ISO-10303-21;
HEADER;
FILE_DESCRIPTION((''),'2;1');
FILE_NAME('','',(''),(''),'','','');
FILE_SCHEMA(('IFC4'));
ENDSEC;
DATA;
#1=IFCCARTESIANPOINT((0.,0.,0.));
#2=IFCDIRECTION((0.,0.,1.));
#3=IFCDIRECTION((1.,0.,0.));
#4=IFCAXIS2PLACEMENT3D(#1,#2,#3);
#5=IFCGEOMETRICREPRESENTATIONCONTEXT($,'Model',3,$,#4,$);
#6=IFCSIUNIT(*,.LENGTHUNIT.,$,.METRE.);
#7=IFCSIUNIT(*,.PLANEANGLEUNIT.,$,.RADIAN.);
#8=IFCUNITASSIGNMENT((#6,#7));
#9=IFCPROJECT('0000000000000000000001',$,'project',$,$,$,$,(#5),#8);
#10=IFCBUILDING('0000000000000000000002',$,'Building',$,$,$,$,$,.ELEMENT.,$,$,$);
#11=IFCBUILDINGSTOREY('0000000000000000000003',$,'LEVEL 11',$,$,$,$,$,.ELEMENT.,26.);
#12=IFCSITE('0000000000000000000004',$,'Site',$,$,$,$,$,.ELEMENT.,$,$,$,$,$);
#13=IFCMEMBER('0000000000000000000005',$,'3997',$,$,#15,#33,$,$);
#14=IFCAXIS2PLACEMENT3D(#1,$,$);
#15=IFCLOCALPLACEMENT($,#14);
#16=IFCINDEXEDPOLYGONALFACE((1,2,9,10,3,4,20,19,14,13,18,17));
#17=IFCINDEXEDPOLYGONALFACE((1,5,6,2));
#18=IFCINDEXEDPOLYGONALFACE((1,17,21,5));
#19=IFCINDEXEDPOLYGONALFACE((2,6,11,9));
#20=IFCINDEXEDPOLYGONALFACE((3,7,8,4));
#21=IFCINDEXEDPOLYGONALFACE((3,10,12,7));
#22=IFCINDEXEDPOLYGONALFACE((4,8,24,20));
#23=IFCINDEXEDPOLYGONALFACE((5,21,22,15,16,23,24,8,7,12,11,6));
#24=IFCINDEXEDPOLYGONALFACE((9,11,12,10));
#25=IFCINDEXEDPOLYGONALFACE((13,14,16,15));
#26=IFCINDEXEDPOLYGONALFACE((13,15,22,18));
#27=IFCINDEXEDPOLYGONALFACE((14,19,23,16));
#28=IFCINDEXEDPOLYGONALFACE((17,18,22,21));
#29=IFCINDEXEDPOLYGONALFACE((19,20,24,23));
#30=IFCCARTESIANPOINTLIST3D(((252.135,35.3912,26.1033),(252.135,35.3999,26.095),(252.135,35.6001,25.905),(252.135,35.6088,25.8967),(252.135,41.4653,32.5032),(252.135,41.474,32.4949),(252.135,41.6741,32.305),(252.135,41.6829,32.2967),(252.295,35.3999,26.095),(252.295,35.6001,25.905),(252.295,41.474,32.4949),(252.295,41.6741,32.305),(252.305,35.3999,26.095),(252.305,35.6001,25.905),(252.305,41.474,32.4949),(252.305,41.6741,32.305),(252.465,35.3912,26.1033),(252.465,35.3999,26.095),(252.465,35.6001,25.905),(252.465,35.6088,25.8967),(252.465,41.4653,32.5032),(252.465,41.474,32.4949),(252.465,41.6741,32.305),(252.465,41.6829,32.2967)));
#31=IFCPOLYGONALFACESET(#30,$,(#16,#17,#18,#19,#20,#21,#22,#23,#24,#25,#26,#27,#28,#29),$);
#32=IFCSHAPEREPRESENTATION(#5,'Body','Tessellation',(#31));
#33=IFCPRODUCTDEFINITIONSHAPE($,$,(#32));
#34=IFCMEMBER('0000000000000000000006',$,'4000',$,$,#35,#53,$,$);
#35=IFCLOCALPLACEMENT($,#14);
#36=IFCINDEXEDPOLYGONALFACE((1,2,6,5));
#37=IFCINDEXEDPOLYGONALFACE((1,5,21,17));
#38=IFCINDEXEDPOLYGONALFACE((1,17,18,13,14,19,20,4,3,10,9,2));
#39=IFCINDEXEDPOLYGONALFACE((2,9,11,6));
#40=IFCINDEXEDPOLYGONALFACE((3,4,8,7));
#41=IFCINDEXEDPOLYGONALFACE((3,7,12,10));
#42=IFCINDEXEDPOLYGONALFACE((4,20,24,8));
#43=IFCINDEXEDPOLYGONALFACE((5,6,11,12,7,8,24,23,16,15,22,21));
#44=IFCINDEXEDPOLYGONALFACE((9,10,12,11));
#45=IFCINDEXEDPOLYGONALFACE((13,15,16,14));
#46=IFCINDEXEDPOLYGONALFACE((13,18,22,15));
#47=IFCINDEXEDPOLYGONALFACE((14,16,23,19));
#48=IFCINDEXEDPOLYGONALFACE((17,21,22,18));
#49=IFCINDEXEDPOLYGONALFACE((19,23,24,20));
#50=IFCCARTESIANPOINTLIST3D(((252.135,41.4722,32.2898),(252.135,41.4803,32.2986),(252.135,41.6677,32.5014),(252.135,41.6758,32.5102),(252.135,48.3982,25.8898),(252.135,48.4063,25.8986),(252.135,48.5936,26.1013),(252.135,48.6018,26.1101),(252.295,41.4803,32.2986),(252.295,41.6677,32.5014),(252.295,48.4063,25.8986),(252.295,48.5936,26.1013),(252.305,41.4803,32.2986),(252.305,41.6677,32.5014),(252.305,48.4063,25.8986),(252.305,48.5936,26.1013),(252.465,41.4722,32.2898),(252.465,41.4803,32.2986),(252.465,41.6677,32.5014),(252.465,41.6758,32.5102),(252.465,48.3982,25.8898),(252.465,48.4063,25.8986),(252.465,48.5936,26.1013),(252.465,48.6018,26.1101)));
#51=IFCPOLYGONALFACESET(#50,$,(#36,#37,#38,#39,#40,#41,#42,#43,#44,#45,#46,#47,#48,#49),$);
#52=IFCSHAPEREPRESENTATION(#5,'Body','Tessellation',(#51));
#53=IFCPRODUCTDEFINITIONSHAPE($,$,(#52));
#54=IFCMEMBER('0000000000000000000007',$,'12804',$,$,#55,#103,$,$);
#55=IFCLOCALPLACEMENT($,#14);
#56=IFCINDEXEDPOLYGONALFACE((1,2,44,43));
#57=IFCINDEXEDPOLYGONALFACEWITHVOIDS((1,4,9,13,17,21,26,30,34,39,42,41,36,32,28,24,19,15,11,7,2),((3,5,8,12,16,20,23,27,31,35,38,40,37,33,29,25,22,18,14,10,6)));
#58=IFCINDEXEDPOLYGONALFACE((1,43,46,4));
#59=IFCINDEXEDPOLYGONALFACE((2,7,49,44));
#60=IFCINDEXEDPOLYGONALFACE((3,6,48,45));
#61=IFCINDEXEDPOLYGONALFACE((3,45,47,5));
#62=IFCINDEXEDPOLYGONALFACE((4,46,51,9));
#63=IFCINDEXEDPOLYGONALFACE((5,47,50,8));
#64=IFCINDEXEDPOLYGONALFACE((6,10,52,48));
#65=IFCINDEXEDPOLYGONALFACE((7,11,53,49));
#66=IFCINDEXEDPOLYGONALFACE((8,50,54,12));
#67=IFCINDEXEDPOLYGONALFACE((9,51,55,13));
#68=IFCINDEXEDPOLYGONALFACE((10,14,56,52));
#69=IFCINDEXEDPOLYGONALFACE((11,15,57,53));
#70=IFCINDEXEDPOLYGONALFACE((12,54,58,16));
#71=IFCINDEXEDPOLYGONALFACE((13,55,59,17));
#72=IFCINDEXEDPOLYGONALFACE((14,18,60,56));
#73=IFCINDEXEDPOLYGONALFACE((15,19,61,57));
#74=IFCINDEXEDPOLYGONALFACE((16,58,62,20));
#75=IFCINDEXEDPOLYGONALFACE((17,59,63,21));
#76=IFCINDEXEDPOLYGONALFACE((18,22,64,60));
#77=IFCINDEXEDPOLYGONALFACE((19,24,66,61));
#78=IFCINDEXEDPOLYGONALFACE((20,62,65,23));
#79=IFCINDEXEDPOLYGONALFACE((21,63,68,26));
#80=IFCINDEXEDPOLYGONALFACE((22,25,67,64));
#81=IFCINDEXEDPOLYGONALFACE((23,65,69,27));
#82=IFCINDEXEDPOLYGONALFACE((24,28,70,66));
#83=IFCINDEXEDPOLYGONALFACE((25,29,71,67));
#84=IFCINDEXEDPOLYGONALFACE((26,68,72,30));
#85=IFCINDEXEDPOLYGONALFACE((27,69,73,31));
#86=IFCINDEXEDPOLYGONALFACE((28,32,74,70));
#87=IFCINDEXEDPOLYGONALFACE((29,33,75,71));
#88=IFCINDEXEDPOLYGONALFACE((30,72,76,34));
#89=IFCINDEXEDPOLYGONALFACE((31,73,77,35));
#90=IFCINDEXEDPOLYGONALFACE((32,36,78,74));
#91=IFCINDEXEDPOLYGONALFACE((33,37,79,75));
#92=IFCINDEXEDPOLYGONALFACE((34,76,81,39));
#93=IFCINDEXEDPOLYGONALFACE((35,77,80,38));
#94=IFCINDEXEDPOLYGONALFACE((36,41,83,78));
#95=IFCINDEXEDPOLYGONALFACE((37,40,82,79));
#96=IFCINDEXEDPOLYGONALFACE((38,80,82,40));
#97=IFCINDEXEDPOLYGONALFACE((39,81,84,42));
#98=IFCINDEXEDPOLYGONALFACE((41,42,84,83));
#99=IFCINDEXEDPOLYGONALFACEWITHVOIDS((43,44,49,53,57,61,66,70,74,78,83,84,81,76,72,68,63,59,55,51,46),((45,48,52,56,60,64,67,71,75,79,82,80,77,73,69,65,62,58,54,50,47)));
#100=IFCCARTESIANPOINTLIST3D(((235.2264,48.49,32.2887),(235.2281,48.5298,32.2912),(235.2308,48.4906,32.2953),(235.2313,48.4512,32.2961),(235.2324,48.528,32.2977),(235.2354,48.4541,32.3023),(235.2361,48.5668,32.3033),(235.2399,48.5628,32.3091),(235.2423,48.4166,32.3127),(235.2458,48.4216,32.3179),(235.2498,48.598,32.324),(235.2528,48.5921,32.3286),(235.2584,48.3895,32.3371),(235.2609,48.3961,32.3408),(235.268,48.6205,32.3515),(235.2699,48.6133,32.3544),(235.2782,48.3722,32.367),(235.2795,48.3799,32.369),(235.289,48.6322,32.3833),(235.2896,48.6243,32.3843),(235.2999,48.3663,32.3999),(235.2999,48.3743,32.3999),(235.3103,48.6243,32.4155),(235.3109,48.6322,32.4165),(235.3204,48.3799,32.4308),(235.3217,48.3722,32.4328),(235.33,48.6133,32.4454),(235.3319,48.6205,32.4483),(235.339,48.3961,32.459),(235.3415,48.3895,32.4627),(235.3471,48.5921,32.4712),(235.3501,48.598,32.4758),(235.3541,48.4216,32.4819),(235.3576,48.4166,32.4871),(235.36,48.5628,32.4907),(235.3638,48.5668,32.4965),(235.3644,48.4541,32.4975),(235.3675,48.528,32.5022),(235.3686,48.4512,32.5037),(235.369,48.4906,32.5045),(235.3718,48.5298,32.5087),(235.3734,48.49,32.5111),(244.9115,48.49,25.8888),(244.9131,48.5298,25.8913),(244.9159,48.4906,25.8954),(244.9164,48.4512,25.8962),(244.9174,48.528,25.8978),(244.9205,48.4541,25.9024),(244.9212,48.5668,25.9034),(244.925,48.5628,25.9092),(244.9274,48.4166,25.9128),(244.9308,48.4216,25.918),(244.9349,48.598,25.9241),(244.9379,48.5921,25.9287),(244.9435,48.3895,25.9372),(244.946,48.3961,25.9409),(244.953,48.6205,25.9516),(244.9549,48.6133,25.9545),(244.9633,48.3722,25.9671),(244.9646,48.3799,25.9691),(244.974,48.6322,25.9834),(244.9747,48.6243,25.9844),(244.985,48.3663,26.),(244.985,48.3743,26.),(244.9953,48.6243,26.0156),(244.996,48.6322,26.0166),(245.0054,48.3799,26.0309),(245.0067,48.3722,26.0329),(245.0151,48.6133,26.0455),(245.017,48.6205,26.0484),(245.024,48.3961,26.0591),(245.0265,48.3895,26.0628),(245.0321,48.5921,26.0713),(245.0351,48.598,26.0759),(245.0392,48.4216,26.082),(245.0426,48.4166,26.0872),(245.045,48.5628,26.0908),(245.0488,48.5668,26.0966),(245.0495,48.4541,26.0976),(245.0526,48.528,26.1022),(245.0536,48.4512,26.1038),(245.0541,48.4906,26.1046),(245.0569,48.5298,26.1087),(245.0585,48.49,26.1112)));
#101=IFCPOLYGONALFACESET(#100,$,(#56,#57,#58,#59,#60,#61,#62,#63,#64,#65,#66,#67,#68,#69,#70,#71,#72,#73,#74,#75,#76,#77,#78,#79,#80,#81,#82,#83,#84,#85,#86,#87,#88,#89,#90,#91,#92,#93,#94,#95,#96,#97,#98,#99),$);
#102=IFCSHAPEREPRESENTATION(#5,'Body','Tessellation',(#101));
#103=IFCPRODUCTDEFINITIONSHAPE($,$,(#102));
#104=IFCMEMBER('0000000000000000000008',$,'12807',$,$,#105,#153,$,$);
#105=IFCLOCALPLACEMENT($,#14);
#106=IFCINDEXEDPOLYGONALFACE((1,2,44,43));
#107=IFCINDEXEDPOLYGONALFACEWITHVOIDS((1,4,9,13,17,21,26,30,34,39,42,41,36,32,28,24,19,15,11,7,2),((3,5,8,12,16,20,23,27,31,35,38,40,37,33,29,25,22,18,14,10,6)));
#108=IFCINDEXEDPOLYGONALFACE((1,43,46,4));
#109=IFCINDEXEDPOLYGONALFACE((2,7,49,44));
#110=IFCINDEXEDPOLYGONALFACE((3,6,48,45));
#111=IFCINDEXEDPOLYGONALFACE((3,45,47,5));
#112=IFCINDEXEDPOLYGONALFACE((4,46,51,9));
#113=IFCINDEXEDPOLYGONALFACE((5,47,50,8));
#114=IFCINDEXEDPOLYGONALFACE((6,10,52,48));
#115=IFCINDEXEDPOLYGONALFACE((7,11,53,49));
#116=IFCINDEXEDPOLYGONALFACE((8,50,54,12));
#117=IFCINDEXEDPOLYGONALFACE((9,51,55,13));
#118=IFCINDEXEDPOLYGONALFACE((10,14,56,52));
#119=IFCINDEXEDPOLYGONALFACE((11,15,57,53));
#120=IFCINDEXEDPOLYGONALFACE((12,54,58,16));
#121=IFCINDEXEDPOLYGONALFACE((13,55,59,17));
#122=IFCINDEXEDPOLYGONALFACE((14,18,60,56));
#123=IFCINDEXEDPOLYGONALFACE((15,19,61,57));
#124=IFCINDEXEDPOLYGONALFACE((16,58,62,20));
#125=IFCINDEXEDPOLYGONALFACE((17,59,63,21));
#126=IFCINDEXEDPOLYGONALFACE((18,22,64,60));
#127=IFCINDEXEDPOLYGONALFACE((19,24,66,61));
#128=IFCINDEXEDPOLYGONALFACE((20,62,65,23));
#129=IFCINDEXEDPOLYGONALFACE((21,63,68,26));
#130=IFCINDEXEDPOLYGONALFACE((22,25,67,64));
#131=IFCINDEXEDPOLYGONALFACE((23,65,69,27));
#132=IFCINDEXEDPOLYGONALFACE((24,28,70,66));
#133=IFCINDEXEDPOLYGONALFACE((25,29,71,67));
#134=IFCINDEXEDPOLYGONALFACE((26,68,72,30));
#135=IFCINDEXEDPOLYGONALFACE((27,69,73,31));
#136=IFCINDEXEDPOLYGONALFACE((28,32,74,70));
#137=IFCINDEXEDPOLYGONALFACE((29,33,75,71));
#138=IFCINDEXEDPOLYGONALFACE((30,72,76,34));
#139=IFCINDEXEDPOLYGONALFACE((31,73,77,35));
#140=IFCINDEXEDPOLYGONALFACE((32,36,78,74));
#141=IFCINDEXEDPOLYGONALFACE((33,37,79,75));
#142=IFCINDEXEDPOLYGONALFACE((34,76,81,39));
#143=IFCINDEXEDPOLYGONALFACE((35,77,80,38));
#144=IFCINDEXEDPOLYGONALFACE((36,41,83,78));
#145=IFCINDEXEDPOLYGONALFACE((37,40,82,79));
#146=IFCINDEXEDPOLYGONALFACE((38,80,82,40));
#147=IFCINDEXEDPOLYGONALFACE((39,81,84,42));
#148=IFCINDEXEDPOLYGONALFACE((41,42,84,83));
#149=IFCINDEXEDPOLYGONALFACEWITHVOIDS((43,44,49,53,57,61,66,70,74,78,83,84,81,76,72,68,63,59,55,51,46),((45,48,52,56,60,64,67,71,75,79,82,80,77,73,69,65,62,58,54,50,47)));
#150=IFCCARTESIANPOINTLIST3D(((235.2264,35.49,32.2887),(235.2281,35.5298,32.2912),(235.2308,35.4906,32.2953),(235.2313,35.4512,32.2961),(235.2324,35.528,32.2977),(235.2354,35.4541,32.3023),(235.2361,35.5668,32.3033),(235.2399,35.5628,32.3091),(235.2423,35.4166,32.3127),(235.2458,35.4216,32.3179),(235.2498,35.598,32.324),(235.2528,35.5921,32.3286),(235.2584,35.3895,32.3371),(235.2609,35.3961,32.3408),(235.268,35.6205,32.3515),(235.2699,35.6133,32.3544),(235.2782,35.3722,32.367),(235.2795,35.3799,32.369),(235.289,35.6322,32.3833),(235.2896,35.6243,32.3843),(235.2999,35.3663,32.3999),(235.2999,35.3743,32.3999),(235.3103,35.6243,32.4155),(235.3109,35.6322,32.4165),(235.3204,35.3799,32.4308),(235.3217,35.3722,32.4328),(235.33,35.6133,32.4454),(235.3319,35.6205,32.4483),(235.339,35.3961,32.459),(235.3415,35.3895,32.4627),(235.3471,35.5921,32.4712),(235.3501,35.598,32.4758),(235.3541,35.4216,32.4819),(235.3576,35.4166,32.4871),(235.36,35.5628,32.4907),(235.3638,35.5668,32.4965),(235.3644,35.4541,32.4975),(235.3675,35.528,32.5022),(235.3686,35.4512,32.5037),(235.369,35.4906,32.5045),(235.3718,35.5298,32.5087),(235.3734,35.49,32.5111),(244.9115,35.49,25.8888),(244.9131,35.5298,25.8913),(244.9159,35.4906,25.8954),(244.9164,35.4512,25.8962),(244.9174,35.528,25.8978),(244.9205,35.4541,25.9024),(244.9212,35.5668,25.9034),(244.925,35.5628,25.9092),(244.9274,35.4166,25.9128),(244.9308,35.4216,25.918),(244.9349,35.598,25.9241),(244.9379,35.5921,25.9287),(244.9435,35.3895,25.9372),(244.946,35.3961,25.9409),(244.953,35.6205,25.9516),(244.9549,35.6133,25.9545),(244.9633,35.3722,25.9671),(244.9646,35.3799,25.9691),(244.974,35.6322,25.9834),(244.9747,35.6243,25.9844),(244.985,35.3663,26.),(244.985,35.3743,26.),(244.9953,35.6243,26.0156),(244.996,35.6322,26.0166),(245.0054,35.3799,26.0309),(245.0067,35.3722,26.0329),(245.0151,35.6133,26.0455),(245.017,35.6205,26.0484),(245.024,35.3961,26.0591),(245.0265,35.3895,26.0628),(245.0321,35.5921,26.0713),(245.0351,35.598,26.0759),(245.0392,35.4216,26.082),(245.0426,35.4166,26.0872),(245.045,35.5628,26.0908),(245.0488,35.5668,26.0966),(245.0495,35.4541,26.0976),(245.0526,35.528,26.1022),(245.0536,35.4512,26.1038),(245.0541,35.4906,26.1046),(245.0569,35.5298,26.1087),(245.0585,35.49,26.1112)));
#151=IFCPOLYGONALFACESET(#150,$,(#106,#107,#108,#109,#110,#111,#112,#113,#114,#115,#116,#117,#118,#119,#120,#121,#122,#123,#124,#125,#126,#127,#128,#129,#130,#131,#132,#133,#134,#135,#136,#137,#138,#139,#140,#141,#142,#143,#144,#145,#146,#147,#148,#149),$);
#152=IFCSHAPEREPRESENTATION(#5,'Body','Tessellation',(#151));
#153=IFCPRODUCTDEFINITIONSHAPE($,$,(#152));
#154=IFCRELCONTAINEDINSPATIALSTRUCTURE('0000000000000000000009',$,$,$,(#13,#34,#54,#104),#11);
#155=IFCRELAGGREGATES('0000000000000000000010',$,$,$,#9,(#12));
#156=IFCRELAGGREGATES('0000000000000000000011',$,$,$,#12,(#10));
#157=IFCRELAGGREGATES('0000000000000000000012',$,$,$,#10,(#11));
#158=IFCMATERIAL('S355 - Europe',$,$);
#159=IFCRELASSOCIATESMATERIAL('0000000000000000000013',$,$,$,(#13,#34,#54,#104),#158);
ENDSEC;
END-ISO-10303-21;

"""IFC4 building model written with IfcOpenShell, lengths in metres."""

from ifc_helpers import new_model, si_unit, frame, origin_with_axes, origin_2d_with_axis, place, context, project, spatial, hollow_circle, i_section, extrude, material, material_profile, profile_set, profile_usage, element, save


model = new_model("IFC4")

# Units and contexts
model_context = context("Model", 3, world=origin_with_axes())
ifc_project = project(units=[si_unit("LENGTHUNIT", "METRE"), si_unit("PLANEANGLEUNIT", "RADIAN")], contexts=[model_context])

# Site, building, storey
site = spatial("IfcSite", under=ifc_project, Name="Site", CompositionType="ELEMENT")
building = spatial("IfcBuilding", under=site, Name="Building", CompositionType="ELEMENT")
storey = spatial("IfcBuildingStorey", under=building, Name="LEVEL 11", CompositionType="ELEMENT", Elevation=26.0)

# Shared definitions
ifc_material = material(Name="S355 - Europe")

# Members
ifc_material_profile_1 = material_profile(ifc_material, i_section(OverallWidth=0.33, OverallDepth=0.3, WebThickness=0.01, FlangeThickness=0.012, at=origin_2d_with_axis()))
ifc_profile_set_1 = profile_set([ifc_material_profile_1])
ifc_profile_usage_1 = profile_usage(ifc_profile_set_1, cardinal=10)
member_1_placement = place(None, frame((252.3, 35.5, 26.0), z_axis=(0.0, 0.688398, 0.725333), x_axis=(-1.0, 0.0, 0.0)))
element("IfcMember", 1, at=member_1_placement, inside=storey, material=ifc_profile_usage_1, Name="3997", context=model_context, shape_type="SweptSolid", body=[
    extrude(i_section(OverallWidth=0.33, OverallDepth=0.3, WebThickness=0.01, FlangeThickness=0.012, at=origin_2d_with_axis()), origin_with_axes(), (0.0, 0.0, 1.0), 8.8235),
])
ifc_material_profile_2 = material_profile(ifc_material, i_section(OverallWidth=0.33, OverallDepth=0.3, WebThickness=0.01, FlangeThickness=0.012, at=origin_2d_with_axis()))
ifc_profile_set_2 = profile_set([ifc_material_profile_2])
ifc_profile_usage_2 = profile_usage(ifc_profile_set_2, cardinal=10)
member_2_placement = place(None, frame((252.3, 41.574, 32.4), z_axis=(0.0, 0.734441, -0.678673), x_axis=(-1.0, 0.0, 0.0)))
element("IfcMember", 2, at=member_2_placement, inside=storey, material=ifc_profile_usage_2, Name="4000", context=model_context, shape_type="SweptSolid", body=[
    extrude(i_section(OverallWidth=0.33, OverallDepth=0.3, WebThickness=0.01, FlangeThickness=0.012, at=origin_2d_with_axis()), origin_with_axes(), (0.0, 0.0, 1.0), 9.4302),
])
ifc_material_profile_3 = material_profile(ifc_material, hollow_circle(Radius=0.1337, WallThickness=0.008, at=origin_2d_with_axis()))
ifc_profile_set_3 = profile_set([ifc_material_profile_3])
ifc_profile_usage_3 = profile_usage(ifc_profile_set_3, cardinal=10)
member_3_placement = place(None, frame((244.985, 48.5, 26.0), z_axis=(-0.834302, 0.0, 0.551308), x_axis=(0.0, -1.0, 0.0)))
element("IfcMember", 3, at=member_3_placement, inside=storey, material=ifc_profile_usage_3, Name="12804", context=model_context, shape_type="SweptSolid", body=[
    extrude(hollow_circle(Radius=0.1337, WallThickness=0.008, at=origin_2d_with_axis()), origin_with_axes(), (0.0, 0.0, 1.0), 11.6086),
])
ifc_material_profile_4 = material_profile(ifc_material, hollow_circle(Radius=0.1337, WallThickness=0.008, at=origin_2d_with_axis()))
ifc_profile_set_4 = profile_set([ifc_material_profile_4])
ifc_profile_usage_4 = profile_usage(ifc_profile_set_4, cardinal=10)
member_4_placement = place(None, frame((244.985, 35.5, 26.0), z_axis=(-0.834302, 0.0, 0.551308), x_axis=(0.0, -1.0, 0.0)))
element("IfcMember", 4, at=member_4_placement, inside=storey, material=ifc_profile_usage_4, Name="12807", context=model_context, shape_type="SweptSolid", body=[
    extrude(hollow_circle(Radius=0.1337, WallThickness=0.008, at=origin_2d_with_axis()), origin_with_axes(), (0.0, 0.0, 1.0), 11.6086),
])

save(model, "model.ifc")
